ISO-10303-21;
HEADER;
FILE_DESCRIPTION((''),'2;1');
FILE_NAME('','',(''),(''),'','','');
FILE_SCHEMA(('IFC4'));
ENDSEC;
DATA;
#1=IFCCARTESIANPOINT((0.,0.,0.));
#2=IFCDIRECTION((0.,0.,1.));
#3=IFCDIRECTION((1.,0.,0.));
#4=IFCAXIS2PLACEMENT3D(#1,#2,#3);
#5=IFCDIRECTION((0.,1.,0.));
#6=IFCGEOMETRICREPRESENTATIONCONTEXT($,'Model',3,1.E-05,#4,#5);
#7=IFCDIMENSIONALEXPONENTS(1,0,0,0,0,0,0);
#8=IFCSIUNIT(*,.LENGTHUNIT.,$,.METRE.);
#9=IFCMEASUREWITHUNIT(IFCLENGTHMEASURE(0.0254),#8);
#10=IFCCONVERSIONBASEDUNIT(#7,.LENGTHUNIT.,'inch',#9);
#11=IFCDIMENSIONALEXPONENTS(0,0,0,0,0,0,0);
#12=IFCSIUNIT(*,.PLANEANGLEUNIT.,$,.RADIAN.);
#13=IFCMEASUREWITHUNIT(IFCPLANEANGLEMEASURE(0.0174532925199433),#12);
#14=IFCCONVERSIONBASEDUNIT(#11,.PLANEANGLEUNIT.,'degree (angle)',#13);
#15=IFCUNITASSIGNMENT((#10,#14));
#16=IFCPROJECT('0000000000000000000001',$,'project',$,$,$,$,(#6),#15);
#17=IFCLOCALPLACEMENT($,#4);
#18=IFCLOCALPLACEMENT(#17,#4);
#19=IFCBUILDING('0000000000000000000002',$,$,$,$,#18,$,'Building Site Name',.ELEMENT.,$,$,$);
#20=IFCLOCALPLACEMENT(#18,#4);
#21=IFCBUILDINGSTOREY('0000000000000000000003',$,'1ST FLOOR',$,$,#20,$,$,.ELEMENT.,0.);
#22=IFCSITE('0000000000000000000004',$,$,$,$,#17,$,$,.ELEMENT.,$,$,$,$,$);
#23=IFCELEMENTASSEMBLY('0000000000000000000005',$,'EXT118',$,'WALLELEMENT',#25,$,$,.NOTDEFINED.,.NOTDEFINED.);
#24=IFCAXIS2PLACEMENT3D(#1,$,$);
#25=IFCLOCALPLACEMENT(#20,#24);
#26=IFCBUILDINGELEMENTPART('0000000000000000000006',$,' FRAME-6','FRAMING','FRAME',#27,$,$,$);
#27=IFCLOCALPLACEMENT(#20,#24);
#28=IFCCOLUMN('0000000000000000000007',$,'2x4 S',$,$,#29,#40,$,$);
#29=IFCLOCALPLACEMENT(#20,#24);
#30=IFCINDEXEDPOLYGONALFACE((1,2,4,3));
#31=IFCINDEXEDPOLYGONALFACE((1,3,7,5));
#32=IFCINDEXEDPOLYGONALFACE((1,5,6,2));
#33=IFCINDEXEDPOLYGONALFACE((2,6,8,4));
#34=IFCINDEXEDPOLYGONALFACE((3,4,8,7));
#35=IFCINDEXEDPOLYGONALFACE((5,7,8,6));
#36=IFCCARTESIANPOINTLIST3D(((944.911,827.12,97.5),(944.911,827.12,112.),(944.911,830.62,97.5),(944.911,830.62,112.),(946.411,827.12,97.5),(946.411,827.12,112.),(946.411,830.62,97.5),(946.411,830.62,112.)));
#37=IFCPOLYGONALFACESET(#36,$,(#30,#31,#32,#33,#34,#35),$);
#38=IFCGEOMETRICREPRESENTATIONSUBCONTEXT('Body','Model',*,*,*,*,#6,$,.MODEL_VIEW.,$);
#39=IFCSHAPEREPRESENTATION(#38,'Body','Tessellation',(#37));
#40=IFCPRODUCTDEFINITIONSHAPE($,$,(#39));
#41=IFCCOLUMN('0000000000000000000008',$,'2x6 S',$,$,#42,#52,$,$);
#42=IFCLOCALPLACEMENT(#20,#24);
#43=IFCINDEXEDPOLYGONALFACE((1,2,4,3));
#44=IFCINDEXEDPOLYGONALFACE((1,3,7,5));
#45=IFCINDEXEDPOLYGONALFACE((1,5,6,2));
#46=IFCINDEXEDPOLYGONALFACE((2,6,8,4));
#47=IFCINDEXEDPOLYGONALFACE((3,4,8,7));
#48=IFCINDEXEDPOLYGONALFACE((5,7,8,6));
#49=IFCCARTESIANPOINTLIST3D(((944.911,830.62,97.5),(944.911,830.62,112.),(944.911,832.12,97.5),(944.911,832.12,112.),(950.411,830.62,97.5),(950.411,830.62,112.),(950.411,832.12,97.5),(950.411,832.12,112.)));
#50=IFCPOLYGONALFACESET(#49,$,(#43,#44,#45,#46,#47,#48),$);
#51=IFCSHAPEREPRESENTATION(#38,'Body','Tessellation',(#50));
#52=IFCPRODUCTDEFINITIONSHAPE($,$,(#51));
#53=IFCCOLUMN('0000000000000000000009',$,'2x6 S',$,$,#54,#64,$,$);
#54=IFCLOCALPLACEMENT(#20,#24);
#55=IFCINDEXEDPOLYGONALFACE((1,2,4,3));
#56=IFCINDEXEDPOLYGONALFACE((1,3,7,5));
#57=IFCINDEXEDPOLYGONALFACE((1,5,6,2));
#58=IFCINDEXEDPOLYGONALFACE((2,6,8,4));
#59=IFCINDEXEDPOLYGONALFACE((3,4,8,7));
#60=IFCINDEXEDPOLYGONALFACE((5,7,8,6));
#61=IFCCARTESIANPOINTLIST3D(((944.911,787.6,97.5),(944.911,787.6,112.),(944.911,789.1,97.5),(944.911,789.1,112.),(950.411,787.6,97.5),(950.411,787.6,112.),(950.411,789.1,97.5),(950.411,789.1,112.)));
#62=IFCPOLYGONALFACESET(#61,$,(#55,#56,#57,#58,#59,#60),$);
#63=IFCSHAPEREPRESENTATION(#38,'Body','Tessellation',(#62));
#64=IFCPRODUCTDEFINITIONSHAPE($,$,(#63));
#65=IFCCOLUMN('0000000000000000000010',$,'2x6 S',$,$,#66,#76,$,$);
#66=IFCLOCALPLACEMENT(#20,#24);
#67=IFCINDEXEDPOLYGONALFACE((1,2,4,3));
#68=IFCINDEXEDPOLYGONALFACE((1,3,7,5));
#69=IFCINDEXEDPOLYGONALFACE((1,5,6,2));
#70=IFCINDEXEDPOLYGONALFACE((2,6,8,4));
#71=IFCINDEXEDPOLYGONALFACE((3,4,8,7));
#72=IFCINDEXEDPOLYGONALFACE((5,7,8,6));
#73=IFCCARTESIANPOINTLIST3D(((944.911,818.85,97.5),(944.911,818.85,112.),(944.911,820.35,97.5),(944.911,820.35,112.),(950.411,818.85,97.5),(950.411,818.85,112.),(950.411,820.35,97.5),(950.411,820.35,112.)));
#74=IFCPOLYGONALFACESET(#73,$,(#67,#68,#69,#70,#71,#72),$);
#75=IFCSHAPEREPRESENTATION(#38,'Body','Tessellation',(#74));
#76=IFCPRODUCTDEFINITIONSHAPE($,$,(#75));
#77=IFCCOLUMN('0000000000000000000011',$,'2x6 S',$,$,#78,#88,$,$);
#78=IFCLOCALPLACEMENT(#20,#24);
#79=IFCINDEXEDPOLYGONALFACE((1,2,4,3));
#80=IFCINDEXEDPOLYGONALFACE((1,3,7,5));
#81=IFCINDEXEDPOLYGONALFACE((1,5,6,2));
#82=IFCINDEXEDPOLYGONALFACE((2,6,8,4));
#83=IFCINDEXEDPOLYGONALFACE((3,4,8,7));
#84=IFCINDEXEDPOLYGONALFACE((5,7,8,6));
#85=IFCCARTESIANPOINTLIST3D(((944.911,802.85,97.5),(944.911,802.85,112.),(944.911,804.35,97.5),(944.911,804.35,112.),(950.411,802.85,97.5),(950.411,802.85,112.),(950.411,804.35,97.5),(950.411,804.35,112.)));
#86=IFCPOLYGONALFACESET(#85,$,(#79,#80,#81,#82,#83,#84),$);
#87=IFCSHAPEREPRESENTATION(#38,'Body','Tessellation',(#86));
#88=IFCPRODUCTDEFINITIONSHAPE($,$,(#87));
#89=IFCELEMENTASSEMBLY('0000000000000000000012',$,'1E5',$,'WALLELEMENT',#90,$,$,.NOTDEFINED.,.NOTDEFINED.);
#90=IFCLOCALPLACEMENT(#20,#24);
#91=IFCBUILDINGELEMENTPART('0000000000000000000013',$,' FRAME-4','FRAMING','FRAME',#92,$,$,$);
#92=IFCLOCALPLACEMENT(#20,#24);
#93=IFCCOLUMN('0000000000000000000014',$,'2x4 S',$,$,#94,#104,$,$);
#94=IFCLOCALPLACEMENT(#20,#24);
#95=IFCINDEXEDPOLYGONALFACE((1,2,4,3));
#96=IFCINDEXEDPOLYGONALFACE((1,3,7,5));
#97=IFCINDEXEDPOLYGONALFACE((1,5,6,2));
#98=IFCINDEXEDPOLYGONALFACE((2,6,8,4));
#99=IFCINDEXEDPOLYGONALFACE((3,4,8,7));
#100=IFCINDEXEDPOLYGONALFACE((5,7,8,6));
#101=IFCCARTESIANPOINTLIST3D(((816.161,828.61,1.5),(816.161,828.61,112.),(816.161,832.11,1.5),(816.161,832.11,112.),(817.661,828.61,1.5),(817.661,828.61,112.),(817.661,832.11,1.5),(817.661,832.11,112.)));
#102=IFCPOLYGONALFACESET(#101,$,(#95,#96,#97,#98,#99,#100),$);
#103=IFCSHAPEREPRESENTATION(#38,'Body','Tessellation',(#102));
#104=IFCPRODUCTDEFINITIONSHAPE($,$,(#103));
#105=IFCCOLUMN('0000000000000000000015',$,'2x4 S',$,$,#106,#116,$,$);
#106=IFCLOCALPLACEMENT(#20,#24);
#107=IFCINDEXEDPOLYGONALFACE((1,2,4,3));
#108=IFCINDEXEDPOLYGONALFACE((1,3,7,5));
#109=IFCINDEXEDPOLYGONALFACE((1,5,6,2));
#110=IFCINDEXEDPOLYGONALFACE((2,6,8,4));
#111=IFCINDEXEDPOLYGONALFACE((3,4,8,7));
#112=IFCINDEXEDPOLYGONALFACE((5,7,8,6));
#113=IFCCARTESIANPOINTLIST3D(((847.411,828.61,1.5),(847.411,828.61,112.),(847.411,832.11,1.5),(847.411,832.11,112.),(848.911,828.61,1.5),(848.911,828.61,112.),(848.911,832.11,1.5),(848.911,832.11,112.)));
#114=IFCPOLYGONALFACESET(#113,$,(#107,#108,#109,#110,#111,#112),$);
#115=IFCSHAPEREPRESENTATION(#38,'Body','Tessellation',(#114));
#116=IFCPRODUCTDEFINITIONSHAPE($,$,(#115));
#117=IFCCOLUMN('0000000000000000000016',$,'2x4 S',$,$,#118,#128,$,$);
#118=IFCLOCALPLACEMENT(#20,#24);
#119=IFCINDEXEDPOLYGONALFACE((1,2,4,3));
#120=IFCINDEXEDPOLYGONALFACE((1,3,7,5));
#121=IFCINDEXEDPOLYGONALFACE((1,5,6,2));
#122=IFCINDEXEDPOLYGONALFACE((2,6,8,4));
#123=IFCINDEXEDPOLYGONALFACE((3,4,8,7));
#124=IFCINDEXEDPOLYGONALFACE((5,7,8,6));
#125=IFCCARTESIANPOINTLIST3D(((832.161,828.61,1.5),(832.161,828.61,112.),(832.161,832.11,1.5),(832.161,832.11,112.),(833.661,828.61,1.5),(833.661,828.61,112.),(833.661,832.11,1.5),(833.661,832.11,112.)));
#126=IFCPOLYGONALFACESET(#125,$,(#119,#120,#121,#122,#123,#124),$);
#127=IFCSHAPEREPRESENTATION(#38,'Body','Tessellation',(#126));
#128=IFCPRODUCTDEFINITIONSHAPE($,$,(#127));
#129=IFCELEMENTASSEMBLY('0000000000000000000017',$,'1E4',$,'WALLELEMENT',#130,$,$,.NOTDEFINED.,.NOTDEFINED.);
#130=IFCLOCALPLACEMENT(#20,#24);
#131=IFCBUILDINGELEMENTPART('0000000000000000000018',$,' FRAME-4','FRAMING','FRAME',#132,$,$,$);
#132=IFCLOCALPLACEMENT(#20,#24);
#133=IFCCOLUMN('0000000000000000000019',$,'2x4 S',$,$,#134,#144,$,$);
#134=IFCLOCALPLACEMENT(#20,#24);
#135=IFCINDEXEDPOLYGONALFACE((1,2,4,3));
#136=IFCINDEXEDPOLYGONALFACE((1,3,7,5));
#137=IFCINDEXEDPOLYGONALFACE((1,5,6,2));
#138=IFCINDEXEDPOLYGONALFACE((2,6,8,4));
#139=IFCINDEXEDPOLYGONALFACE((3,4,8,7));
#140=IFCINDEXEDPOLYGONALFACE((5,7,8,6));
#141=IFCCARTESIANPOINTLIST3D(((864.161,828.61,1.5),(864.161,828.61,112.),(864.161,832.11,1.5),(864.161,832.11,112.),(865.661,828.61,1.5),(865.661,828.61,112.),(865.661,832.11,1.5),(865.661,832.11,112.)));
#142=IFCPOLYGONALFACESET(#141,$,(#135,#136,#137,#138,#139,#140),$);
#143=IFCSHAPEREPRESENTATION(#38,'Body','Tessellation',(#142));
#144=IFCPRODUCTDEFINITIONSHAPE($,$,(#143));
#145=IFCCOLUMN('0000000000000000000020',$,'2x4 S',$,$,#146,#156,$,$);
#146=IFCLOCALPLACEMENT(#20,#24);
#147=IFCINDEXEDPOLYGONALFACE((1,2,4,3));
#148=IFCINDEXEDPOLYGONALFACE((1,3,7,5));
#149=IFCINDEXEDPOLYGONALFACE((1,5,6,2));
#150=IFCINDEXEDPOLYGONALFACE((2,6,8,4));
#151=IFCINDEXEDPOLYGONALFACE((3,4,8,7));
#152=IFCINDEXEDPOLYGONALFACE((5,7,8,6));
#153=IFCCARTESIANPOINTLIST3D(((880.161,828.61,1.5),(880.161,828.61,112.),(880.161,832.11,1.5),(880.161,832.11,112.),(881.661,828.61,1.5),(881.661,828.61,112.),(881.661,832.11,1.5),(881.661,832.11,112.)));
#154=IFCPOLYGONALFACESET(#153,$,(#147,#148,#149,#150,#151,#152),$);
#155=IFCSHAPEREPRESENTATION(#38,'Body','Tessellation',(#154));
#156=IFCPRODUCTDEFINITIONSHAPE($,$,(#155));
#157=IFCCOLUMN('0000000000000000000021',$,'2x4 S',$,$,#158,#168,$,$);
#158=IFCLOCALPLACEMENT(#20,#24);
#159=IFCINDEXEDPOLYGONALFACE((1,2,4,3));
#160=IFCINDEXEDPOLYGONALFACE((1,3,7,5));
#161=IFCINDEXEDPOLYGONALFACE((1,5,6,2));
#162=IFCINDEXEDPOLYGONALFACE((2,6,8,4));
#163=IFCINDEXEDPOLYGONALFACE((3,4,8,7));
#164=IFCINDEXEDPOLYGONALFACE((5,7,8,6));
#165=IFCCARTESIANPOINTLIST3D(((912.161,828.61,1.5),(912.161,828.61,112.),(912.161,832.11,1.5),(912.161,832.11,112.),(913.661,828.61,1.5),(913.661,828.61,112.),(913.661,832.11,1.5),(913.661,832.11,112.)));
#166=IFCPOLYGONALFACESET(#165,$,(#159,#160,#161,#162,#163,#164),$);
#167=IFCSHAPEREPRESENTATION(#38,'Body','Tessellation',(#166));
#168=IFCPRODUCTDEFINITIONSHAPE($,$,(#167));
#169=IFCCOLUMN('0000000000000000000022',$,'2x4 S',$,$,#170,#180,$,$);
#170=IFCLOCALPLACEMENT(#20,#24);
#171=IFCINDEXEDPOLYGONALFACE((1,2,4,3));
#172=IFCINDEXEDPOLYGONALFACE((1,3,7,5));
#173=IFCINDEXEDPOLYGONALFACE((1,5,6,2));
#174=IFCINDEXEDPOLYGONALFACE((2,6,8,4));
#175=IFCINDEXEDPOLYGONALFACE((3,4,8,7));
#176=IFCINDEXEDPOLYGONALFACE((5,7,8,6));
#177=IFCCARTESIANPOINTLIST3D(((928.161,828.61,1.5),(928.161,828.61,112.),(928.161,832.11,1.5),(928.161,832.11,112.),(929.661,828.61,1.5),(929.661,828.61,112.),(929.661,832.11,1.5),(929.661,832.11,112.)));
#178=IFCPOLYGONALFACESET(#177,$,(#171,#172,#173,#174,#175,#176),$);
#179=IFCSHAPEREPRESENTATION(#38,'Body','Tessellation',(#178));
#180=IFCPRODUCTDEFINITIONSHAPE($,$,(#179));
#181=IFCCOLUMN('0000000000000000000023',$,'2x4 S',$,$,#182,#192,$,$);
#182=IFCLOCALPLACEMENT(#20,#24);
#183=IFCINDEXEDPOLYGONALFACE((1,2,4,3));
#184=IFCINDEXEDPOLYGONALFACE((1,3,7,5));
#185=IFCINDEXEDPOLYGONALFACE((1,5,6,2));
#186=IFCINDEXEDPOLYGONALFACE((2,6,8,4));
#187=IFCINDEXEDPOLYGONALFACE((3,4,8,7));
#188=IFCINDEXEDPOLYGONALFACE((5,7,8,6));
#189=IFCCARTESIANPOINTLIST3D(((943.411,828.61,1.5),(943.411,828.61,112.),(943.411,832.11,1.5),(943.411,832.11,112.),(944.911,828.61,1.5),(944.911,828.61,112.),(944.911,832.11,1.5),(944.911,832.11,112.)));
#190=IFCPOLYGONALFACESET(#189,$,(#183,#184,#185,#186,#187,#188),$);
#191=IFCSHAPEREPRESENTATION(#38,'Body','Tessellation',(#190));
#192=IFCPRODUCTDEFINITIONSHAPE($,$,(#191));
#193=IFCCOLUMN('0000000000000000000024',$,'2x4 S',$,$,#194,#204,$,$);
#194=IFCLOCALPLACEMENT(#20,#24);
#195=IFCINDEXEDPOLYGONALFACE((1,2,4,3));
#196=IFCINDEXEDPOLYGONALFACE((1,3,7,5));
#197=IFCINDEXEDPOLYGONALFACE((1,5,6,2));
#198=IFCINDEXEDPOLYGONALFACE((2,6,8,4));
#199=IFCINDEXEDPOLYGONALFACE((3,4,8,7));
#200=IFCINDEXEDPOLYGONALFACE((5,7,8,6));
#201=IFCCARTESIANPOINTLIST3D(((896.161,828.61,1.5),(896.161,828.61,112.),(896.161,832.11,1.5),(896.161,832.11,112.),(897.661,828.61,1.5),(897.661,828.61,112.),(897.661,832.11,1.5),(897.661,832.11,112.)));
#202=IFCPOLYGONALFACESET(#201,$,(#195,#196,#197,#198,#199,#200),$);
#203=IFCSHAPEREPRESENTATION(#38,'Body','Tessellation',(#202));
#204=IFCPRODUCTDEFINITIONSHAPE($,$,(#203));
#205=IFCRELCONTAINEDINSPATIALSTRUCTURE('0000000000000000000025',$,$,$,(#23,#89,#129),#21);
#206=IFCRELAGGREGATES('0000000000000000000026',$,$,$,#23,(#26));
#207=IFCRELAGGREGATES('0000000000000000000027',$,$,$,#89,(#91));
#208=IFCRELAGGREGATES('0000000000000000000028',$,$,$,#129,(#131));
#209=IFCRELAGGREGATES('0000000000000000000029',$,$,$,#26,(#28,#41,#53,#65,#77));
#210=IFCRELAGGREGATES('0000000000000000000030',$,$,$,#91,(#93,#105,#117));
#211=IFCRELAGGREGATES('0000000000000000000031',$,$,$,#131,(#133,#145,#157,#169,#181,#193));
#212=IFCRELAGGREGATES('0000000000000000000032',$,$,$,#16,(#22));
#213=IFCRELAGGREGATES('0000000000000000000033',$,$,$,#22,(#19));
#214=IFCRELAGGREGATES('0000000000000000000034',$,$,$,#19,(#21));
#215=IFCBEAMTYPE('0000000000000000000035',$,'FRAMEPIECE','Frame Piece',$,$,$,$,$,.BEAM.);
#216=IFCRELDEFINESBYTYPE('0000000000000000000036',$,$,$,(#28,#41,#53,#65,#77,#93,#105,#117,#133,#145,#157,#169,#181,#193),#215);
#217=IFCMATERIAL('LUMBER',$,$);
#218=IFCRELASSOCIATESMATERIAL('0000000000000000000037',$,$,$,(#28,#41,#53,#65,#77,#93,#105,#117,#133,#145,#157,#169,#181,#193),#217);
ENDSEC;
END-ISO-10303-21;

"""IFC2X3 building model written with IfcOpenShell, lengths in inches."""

from ifc_helpers import new_model, entity, si_unit, converted_unit, direction, frame, frame_2d, origin_with_axes, place, context, subcontext, project, spatial, rectangle, extrude, material, type_object, element, aggregate, save


model = new_model("IFC2X3")

# Units and contexts
model_context = context("Model", 3, precision=1e-05, world=origin_with_axes(), true_north=direction((0.0, 1.0, 0.0)))
body_context = subcontext(model_context, "Body", "Model", "MODEL_VIEW")
ifc_project = project(units=[converted_unit("LENGTHUNIT", "inch", entity("IfcLengthMeasure", 0.0254), si_unit("LENGTHUNIT", "METRE"), dimensions=[1, 0, 0, 0, 0, 0, 0]), converted_unit("PLANEANGLEUNIT", "degree (angle)", entity("IfcPlaneAngleMeasure", 0.0174532925199433), si_unit("PLANEANGLEUNIT", "RADIAN"), dimensions=[0, 0, 0, 0, 0, 0, 0])], contexts=[model_context])

# Site, building, storey
site_placement = place(None, origin_with_axes())
site = spatial("IfcSite", under=ifc_project, at=site_placement, CompositionType="ELEMENT")
building_placement = place(site_placement, origin_with_axes())
building = spatial("IfcBuilding", under=site, at=building_placement, LongName="Building Site Name", CompositionType="ELEMENT")
storey_placement = place(building_placement, origin_with_axes())
storey = spatial("IfcBuildingStorey", under=building, at=storey_placement, Name="1ST FLOOR", CompositionType="ELEMENT", Elevation=0.0)

# Element assemblies, building element parts, columns
assembly_1_placement = place(storey_placement, origin_with_axes())
assembly_1 = element("IfcElementAssembly", 1, at=assembly_1_placement, inside=storey, Name="EXT118", ObjectType="WALLELEMENT", AssemblyPlace="NOTDEFINED", PredefinedType="NOTDEFINED")
building_element_part_1 = element("IfcBuildingElementPart", 2, Name=" FRAME-6", Description="FRAMING", ObjectType="FRAME")
aggregate(assembly_1, [building_element_part_1])
ifc_material_1 = material(Name="LUMBER")
beam_type = type_object("IfcBeamType", Name="FRAMEPIECE", Description="Frame Piece", PredefinedType="BEAM")
column_1_placement = place(assembly_1_placement, frame((945.661, 828.87, 97.5), z_axis=(0.0, 0.0, 1.0), x_axis=(-1.0, 0.0, 0.0)))
column_1 = element("IfcColumn", 3, at=column_1_placement, type_object=beam_type, material=ifc_material_1, Name="2x4 S", context=body_context, shape_type="SweptSolid", body=[
    extrude(rectangle(XDim=1.5, YDim=3.5, at=frame_2d((0.0, 0.0), x_axis=(-1.0, 0.0))), origin_with_axes(), (0.0, 0.0, 1.0), 14.5),
])
column_2_placement = place(assembly_1_placement, frame((947.661, 831.37, 97.5), z_axis=(0.0, 0.0, 1.0), x_axis=(0.0, -1.0, 0.0)))
column_2 = element("IfcColumn", 4, at=column_2_placement, type_object=beam_type, material=ifc_material_1, Name="2x6 S", context=body_context, shape_type="SweptSolid", body=[
    extrude(rectangle(XDim=1.5, YDim=5.5, at=frame_2d((0.0, 0.0), x_axis=(-1.0, 0.0))), origin_with_axes(), (0.0, 0.0, 1.0), 14.5),
])
column_3_placement = place(assembly_1_placement, frame((947.661, 788.35, 112.0), z_axis=(0.0, 0.0, -1.0), x_axis=(0.0, 1.0, 0.0)))
column_3 = element("IfcColumn", 5, at=column_3_placement, type_object=beam_type, material=ifc_material_1, Name="2x6 S", context=body_context, shape_type="SweptSolid", body=[
    extrude(rectangle(XDim=1.5, YDim=5.5, at=frame_2d((0.0, 0.0), x_axis=(-1.0, 0.0))), origin_with_axes(), (0.0, 0.0, 1.0), 14.5),
])
column_4_placement = place(assembly_1_placement, frame((947.661, 819.6, 112.0), z_axis=(0.0, 0.0, -1.0), x_axis=(0.0, 1.0, 0.0)))
column_4 = element("IfcColumn", 6, at=column_4_placement, type_object=beam_type, material=ifc_material_1, Name="2x6 S", context=body_context, shape_type="SweptSolid", body=[
    extrude(rectangle(XDim=1.5, YDim=5.5, at=frame_2d((0.0, 0.0), x_axis=(-1.0, 0.0))), origin_with_axes(), (0.0, 0.0, 1.0), 14.5),
])
column_5_placement = place(assembly_1_placement, frame((947.661, 803.6, 112.0), z_axis=(0.0, 0.0, -1.0), x_axis=(0.0, 1.0, 0.0)))
column_5 = element("IfcColumn", 7, at=column_5_placement, type_object=beam_type, material=ifc_material_1, Name="2x6 S", context=body_context, shape_type="SweptSolid", body=[
    extrude(rectangle(XDim=1.5, YDim=5.5, at=frame_2d((0.0, 0.0), x_axis=(-1.0, 0.0))), origin_with_axes(), (0.0, 0.0, 1.0), 14.5),
])
assembly_2_placement = place(storey_placement, origin_with_axes())
assembly_2 = element("IfcElementAssembly", 8, at=assembly_2_placement, inside=storey, Name="1E5", ObjectType="WALLELEMENT", AssemblyPlace="NOTDEFINED", PredefinedType="NOTDEFINED")
building_element_part_2 = element("IfcBuildingElementPart", 9, Name=" FRAME-4", Description="FRAMING", ObjectType="FRAME")
aggregate(assembly_2, [building_element_part_2])
column_6_placement = place(assembly_2_placement, frame((816.911, 830.36, 112.0), z_axis=(0.0, 0.0, -1.0), x_axis=(-1.0, 0.0, 0.0)))
column_6 = element("IfcColumn", 10, at=column_6_placement, type_object=beam_type, material=ifc_material_1, Name="2x4 S", context=body_context, shape_type="SweptSolid", body=[
    extrude(rectangle(XDim=1.5, YDim=3.5, at=frame_2d((0.0, 0.0), x_axis=(-1.0, 0.0))), origin_with_axes(), (0.0, 0.0, 1.0), 110.5),
])
column_7_placement = place(assembly_2_placement, frame((848.161, 830.36, 112.0), z_axis=(0.0, 0.0, -1.0), x_axis=(-1.0, 0.0, 0.0)))
column_7 = element("IfcColumn", 11, at=column_7_placement, type_object=beam_type, material=ifc_material_1, Name="2x4 S", context=body_context, shape_type="SweptSolid", body=[
    extrude(rectangle(XDim=1.5, YDim=3.5, at=frame_2d((0.0, 0.0), x_axis=(-1.0, 0.0))), origin_with_axes(), (0.0, 0.0, 1.0), 110.5),
])
column_8_placement = place(assembly_2_placement, frame((832.911, 830.36, 112.0), z_axis=(0.0, 0.0, -1.0), x_axis=(-1.0, 0.0, 0.0)))
column_8 = element("IfcColumn", 12, at=column_8_placement, type_object=beam_type, material=ifc_material_1, Name="2x4 S", context=body_context, shape_type="SweptSolid", body=[
    extrude(rectangle(XDim=1.5, YDim=3.5, at=frame_2d((0.0, 0.0), x_axis=(-1.0, 0.0))), origin_with_axes(), (0.0, 0.0, 1.0), 110.5),
])
assembly_3_placement = place(storey_placement, origin_with_axes())
assembly_3 = element("IfcElementAssembly", 13, at=assembly_3_placement, inside=storey, Name="1E4", ObjectType="WALLELEMENT", AssemblyPlace="NOTDEFINED", PredefinedType="NOTDEFINED")
building_element_part_3 = element("IfcBuildingElementPart", 14, Name=" FRAME-4", Description="FRAMING", ObjectType="FRAME")
aggregate(assembly_3, [building_element_part_3])
column_9_placement = place(assembly_3_placement, frame((864.911, 830.36, 112.0), z_axis=(0.0, 0.0, -1.0), x_axis=(-1.0, 0.0, 0.0)))
column_9 = element("IfcColumn", 15, at=column_9_placement, type_object=beam_type, material=ifc_material_1, Name="2x4 S", context=body_context, shape_type="SweptSolid", body=[
    extrude(rectangle(XDim=1.5, YDim=3.5, at=frame_2d((0.0, 0.0), x_axis=(-1.0, 0.0))), origin_with_axes(), (0.0, 0.0, 1.0), 110.5),
])
column_10_placement = place(assembly_3_placement, frame((880.911, 830.36, 112.0), z_axis=(0.0, 0.0, -1.0), x_axis=(-1.0, 0.0, 0.0)))
column_10 = element("IfcColumn", 16, at=column_10_placement, type_object=beam_type, material=ifc_material_1, Name="2x4 S", context=body_context, shape_type="SweptSolid", body=[
    extrude(rectangle(XDim=1.5, YDim=3.5, at=frame_2d((0.0, 0.0), x_axis=(-1.0, 0.0))), origin_with_axes(), (0.0, 0.0, 1.0), 110.5),
])
column_11_placement = place(assembly_3_placement, frame((912.911, 830.36, 112.0), z_axis=(0.0, 0.0, -1.0), x_axis=(-1.0, 0.0, 0.0)))
column_11 = element("IfcColumn", 17, at=column_11_placement, type_object=beam_type, material=ifc_material_1, Name="2x4 S", context=body_context, shape_type="SweptSolid", body=[
    extrude(rectangle(XDim=1.5, YDim=3.5, at=frame_2d((0.0, 0.0), x_axis=(-1.0, 0.0))), origin_with_axes(), (0.0, 0.0, 1.0), 110.5),
])
column_12_placement = place(assembly_3_placement, frame((928.911, 830.36, 112.0), z_axis=(0.0, 0.0, -1.0), x_axis=(-1.0, 0.0, 0.0)))
column_12 = element("IfcColumn", 18, at=column_12_placement, type_object=beam_type, material=ifc_material_1, Name="2x4 S", context=body_context, shape_type="SweptSolid", body=[
    extrude(rectangle(XDim=1.5, YDim=3.5, at=frame_2d((0.0, 0.0), x_axis=(-1.0, 0.0))), origin_with_axes(), (0.0, 0.0, 1.0), 110.5),
])
column_13_placement = place(assembly_3_placement, frame((944.161, 830.36, 112.0), z_axis=(0.0, 0.0, -1.0), x_axis=(-1.0, 0.0, 0.0)))
column_13 = element("IfcColumn", 19, at=column_13_placement, type_object=beam_type, material=ifc_material_1, Name="2x4 S", context=body_context, shape_type="SweptSolid", body=[
    extrude(rectangle(XDim=1.5, YDim=3.5, at=frame_2d((0.0, 0.0), x_axis=(-1.0, 0.0))), origin_with_axes(), (0.0, 0.0, 1.0), 110.5),
])
column_14_placement = place(assembly_3_placement, frame((896.911, 830.36, 112.0), z_axis=(0.0, 0.0, -1.0), x_axis=(-1.0, 0.0, 0.0)))
column_14 = element("IfcColumn", 20, at=column_14_placement, type_object=beam_type, material=ifc_material_1, Name="2x4 S", context=body_context, shape_type="SweptSolid", body=[
    extrude(rectangle(XDim=1.5, YDim=3.5, at=frame_2d((0.0, 0.0), x_axis=(-1.0, 0.0))), origin_with_axes(), (0.0, 0.0, 1.0), 110.5),
])

aggregate(building_element_part_1, [column_1, column_2, column_3, column_4, column_5])

aggregate(building_element_part_2, [column_6, column_7, column_8])
aggregate(building_element_part_3, [column_9, column_10, column_11, column_12, column_13, column_14])

save(model, "model.ifc")
